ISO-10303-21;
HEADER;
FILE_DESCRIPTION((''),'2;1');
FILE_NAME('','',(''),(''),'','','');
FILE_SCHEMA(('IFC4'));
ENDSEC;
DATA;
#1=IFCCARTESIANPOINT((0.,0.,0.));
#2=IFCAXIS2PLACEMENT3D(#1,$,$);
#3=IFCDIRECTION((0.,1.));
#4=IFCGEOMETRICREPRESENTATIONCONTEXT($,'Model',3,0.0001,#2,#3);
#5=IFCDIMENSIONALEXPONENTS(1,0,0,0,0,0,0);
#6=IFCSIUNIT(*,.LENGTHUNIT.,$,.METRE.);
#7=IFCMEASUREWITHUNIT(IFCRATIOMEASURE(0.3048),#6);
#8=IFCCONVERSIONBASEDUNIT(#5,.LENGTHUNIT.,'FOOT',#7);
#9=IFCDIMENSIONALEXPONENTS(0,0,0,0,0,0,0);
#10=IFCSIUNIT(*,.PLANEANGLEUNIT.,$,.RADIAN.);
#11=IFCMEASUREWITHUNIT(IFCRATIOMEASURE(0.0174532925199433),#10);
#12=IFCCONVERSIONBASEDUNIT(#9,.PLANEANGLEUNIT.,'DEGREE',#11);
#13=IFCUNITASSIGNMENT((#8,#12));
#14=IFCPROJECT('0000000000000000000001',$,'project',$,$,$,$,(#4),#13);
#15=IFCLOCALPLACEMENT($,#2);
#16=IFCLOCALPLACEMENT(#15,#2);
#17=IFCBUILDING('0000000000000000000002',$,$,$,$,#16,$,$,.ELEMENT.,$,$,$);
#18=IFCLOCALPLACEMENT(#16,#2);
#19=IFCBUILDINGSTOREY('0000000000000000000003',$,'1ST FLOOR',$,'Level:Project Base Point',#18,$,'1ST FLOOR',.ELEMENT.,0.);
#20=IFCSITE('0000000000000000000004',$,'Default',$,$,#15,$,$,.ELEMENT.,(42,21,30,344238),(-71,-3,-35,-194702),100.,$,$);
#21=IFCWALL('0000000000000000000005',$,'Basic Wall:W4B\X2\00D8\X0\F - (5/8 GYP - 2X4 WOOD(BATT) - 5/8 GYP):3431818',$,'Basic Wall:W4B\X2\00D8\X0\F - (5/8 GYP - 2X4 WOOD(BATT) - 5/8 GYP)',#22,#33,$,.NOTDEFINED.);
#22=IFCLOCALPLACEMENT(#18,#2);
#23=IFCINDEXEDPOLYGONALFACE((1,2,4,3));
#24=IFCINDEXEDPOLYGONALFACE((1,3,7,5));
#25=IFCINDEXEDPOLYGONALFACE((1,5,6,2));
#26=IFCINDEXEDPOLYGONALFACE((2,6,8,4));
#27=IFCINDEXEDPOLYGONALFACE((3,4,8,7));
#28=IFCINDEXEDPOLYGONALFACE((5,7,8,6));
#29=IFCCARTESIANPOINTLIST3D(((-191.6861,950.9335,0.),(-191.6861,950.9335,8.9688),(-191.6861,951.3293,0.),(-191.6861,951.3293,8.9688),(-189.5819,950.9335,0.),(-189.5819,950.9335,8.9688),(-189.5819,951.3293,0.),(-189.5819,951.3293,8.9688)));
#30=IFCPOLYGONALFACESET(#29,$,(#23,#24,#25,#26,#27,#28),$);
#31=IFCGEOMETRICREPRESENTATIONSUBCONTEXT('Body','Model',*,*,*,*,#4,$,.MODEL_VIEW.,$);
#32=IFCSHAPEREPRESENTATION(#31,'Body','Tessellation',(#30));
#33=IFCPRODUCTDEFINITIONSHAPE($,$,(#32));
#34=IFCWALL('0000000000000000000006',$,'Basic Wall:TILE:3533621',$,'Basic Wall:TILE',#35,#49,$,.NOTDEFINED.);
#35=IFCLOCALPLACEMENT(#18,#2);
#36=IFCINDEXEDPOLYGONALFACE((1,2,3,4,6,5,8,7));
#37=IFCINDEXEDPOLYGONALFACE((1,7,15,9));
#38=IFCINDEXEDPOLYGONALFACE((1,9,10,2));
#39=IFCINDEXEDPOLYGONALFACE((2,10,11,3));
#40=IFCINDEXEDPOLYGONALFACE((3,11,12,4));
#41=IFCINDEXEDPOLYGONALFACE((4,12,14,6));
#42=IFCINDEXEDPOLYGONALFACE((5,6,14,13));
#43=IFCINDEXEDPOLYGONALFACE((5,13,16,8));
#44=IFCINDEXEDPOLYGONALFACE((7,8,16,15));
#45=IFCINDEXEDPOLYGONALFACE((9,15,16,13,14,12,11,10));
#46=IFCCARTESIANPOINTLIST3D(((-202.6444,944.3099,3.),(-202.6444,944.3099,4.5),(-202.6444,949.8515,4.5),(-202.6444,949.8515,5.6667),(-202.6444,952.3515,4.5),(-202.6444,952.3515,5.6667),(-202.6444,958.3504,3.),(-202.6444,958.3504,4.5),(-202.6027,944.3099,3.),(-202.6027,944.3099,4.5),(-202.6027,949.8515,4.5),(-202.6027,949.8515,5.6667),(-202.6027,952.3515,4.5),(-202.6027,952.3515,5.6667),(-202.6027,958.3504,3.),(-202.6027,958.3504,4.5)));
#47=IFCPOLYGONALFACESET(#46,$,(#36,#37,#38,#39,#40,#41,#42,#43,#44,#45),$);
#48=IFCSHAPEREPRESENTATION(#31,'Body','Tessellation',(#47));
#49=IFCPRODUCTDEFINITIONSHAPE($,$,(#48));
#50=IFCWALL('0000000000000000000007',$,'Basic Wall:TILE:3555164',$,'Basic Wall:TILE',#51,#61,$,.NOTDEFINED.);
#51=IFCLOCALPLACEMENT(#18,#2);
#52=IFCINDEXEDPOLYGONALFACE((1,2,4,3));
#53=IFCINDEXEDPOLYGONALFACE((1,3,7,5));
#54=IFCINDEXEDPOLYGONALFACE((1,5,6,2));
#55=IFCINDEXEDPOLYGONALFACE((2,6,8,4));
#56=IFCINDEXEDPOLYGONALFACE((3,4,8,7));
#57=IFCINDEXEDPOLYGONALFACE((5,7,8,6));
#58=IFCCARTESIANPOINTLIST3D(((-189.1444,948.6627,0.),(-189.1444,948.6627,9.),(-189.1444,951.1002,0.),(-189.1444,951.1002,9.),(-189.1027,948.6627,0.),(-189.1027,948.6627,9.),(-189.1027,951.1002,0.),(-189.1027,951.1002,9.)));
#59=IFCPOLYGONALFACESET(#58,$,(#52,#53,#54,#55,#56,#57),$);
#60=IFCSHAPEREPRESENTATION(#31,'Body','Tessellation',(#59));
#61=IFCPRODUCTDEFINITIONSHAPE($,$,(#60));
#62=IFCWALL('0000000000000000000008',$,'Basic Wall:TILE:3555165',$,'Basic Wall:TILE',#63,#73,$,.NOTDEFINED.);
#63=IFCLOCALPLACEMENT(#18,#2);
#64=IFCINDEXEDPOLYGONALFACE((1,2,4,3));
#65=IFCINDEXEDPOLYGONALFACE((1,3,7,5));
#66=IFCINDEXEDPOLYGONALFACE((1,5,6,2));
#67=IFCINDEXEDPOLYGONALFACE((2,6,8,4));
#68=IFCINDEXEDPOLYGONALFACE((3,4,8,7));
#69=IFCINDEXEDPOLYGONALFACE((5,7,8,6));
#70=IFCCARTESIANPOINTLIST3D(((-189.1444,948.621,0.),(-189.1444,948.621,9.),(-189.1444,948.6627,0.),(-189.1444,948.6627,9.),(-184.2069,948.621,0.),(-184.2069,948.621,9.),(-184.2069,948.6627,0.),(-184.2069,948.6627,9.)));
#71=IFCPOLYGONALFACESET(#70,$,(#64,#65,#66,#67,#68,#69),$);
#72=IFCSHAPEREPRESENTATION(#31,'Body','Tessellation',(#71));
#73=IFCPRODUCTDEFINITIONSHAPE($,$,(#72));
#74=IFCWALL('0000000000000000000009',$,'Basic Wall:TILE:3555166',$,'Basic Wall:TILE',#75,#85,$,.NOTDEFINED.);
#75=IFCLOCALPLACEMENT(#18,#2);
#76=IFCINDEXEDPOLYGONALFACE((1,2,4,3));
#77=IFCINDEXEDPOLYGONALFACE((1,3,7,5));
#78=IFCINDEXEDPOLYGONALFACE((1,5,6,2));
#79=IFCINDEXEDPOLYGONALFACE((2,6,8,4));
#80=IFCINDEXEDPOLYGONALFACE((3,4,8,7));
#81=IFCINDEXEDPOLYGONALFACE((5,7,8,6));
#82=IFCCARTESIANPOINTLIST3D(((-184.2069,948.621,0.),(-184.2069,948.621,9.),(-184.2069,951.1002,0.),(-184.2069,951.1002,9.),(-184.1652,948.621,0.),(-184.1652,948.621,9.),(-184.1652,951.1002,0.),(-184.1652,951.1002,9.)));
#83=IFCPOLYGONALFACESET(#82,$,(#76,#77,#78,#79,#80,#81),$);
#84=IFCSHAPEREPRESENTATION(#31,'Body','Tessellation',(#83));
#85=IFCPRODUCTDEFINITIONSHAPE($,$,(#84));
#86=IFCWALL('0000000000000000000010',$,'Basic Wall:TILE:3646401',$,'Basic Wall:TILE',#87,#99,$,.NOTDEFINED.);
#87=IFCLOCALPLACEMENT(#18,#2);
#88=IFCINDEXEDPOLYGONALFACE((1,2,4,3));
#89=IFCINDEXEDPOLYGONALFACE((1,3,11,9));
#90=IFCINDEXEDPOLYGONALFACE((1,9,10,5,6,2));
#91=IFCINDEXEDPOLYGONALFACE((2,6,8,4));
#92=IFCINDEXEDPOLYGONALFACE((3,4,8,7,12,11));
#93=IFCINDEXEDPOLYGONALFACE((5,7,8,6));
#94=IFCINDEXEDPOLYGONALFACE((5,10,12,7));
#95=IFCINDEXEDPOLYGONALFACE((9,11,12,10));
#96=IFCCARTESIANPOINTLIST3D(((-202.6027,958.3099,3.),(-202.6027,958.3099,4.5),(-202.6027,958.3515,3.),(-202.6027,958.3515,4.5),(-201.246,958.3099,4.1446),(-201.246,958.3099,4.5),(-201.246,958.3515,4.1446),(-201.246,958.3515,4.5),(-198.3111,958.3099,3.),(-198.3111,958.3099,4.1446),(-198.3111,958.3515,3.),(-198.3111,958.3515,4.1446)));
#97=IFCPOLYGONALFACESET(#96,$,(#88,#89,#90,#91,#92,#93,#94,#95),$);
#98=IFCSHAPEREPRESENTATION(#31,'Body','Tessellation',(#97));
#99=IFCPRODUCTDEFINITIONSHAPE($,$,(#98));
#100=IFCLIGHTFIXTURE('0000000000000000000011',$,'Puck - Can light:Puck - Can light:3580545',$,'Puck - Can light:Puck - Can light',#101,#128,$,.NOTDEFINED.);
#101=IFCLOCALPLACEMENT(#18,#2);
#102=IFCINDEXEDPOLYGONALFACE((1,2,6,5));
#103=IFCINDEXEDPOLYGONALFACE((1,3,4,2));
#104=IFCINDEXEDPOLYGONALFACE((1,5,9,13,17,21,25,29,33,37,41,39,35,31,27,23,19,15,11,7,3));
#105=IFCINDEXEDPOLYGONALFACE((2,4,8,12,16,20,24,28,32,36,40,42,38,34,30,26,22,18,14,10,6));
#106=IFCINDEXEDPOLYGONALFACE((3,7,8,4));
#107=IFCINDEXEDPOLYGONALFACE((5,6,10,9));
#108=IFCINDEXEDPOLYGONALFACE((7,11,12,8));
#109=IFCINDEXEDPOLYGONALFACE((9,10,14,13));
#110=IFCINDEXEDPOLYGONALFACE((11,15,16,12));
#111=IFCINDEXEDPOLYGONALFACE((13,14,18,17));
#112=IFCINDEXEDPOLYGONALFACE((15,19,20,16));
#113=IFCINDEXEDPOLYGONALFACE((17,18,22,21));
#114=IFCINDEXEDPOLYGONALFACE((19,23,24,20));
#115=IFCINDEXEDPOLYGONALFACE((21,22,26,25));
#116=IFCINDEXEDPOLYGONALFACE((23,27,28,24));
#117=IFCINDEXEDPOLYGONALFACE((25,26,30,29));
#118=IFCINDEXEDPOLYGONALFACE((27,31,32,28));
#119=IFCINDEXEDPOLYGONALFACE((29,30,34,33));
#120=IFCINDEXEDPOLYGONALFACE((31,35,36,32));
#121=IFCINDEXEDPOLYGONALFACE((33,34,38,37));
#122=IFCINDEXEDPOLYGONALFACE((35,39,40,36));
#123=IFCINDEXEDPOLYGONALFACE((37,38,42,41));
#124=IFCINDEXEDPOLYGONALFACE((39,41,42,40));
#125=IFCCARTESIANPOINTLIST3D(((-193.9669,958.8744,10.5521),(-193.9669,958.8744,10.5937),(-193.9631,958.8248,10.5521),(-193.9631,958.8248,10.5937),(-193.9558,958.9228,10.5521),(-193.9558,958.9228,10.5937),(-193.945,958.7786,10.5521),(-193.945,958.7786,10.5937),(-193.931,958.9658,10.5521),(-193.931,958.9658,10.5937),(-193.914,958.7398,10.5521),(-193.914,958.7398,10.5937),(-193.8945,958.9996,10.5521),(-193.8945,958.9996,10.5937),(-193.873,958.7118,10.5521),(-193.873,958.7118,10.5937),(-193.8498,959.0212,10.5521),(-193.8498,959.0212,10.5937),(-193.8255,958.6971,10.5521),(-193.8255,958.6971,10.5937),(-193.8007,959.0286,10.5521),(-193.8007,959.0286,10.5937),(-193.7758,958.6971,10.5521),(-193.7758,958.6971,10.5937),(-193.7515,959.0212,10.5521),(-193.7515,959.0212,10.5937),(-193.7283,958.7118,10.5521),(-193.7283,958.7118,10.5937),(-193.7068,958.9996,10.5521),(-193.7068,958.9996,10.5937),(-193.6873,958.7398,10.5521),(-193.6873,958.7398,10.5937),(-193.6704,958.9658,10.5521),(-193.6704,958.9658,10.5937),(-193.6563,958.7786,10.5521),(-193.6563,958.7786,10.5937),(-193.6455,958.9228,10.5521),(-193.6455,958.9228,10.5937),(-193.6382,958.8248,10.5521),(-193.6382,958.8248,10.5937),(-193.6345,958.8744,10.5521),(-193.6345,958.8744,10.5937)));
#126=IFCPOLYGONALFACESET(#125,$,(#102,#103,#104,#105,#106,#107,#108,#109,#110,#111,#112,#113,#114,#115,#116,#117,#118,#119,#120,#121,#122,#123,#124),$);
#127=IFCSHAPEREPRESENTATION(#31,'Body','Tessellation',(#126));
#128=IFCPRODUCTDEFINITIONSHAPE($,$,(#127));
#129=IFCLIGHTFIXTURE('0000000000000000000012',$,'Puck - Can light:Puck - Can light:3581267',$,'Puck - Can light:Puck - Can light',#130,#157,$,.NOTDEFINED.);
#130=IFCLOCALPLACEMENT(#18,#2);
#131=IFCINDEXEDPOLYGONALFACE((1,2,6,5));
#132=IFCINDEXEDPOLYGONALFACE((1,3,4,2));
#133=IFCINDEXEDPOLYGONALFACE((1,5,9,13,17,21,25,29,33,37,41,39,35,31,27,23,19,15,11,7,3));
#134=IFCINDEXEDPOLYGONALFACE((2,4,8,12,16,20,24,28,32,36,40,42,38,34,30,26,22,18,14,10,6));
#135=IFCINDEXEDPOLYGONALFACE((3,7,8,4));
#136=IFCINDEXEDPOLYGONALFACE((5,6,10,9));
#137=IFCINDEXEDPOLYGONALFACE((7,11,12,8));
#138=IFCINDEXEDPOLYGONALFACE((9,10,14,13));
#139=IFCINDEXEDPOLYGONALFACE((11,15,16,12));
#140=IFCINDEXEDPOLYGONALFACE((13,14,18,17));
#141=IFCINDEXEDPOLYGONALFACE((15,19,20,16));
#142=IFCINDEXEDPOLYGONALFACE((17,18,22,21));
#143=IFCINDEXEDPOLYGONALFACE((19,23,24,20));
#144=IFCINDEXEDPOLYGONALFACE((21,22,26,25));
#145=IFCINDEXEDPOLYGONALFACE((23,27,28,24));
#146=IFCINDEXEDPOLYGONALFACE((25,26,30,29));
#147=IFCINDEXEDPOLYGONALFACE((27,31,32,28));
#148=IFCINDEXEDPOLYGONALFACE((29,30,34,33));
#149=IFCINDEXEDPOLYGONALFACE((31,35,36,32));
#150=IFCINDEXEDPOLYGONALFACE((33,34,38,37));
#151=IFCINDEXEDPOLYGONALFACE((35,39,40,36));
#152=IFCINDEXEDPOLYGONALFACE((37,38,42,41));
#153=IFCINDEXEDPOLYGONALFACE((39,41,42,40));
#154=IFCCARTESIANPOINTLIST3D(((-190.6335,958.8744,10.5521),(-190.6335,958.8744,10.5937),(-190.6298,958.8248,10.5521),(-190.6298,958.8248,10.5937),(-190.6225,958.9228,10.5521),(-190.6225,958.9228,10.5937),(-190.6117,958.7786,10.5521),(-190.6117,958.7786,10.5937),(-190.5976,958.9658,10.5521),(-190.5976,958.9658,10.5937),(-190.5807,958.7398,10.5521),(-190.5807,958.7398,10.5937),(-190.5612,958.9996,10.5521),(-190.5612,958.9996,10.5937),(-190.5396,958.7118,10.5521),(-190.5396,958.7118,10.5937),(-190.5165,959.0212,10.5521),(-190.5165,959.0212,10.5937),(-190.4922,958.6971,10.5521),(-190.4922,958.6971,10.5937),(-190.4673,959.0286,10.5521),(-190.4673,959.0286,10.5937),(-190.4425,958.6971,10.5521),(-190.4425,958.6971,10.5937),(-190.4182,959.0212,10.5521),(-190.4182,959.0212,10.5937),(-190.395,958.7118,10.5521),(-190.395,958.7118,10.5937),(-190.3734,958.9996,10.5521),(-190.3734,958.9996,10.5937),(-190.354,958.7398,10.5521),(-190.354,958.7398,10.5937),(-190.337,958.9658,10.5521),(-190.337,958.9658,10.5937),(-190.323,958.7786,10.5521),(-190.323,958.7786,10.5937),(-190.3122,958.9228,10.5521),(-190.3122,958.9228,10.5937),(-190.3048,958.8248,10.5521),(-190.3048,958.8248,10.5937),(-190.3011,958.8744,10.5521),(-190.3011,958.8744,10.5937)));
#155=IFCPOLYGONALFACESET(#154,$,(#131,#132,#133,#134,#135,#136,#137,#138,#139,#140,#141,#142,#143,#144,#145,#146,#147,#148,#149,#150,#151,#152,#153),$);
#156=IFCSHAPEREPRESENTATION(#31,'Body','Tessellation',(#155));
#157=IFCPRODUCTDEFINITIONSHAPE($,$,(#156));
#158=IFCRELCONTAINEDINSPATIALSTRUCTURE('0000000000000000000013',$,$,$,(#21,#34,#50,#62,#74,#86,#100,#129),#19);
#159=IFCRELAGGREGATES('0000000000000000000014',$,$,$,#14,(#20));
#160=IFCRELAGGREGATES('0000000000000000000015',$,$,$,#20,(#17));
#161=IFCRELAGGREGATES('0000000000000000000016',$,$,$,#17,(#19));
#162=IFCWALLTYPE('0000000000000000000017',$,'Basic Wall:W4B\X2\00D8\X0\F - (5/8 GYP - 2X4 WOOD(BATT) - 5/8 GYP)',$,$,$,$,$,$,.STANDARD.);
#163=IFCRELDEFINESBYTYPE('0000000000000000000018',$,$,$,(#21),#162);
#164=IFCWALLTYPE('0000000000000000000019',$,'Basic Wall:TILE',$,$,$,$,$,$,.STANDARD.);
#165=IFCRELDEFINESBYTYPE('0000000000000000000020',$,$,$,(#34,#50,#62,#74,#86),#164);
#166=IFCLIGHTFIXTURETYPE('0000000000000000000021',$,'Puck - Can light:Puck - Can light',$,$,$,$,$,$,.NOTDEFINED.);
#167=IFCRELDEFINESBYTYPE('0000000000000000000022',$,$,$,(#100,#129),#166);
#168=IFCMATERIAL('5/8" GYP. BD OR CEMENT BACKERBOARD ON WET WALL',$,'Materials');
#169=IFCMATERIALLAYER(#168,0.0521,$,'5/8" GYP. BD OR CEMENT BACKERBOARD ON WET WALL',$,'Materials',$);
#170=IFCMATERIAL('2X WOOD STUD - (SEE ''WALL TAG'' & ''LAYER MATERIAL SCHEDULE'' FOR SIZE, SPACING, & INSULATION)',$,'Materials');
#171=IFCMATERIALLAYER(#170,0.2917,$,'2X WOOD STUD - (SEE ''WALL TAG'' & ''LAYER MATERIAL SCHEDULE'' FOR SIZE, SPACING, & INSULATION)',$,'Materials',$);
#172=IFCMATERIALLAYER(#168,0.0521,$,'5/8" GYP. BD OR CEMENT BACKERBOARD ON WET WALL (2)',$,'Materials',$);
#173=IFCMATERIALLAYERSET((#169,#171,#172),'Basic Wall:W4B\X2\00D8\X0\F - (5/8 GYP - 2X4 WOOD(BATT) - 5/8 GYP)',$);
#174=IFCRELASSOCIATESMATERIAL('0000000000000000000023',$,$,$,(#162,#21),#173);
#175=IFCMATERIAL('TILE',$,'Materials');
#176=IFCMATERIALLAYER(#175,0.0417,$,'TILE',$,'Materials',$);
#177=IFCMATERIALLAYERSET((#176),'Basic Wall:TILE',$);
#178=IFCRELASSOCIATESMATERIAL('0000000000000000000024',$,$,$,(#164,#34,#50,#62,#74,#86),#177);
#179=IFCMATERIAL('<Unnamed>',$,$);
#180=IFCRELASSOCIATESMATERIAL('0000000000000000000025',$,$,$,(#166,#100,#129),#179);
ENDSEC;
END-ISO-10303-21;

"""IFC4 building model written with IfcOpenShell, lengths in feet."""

from ifc_helpers import new_model, entity, si_unit, converted_unit, direction, frame, frame_2d, origin, origin_2d_with_axis, place, context, subcontext, project, spatial, rectangle, circle, extrude, source, transform, mapped, material, layer, layer_set, layer_usage, type_object, type_shapes, element, save


model = new_model("IFC4")

# Units and contexts
model_context = context("Model", 3, precision=0.0001, world=origin(), true_north=direction((0.0, 1.0)))
body_context = subcontext(model_context, "Body", "Model", "MODEL_VIEW")
ifc_project = project(units=[converted_unit("LENGTHUNIT", "FOOT", entity("IfcRatioMeasure", 0.3048), si_unit("LENGTHUNIT", "METRE"), dimensions=[1, 0, 0, 0, 0, 0, 0]), converted_unit("PLANEANGLEUNIT", "DEGREE", entity("IfcRatioMeasure", 0.0174532925199433), si_unit("PLANEANGLEUNIT", "RADIAN"), dimensions=[0, 0, 0, 0, 0, 0, 0])], contexts=[model_context])

# Site, building, storey
site_placement = place(None, origin())
site = spatial("IfcSite", under=ifc_project, at=site_placement, Name="Default", CompositionType="ELEMENT", RefLatitude=(42, 21, 30, 344238), RefLongitude=(-71, -3, -35, -194702), RefElevation=100.0)
building_placement = place(site_placement, origin())
building = spatial("IfcBuilding", under=site, at=building_placement, CompositionType="ELEMENT")
storey_placement = place(building_placement, origin())
storey = spatial("IfcBuildingStorey", under=building, at=storey_placement, Name="1ST FLOOR", ObjectType="Level:Project Base Point", LongName="1ST FLOOR", CompositionType="ELEMENT", Elevation=0.0)

# Shared definitions
ifc_material_1 = material(Name="5/8\" GYP. BD OR CEMENT BACKERBOARD ON WET WALL", Category="Materials")
ifc_layer_1 = layer(ifc_material_1, 0.0521, Name="5/8\" GYP. BD OR CEMENT BACKERBOARD ON WET WALL", Category="Materials")
ifc_material_2 = material(Name="2X WOOD STUD - (SEE 'WALL TAG' & 'LAYER MATERIAL SCHEDULE' FOR SIZE, SPACING, & INSULATION)", Category="Materials")
ifc_layer_2 = layer(ifc_material_2, 0.2917, Name="2X WOOD STUD - (SEE 'WALL TAG' & 'LAYER MATERIAL SCHEDULE' FOR SIZE, SPACING, & INSULATION)", Category="Materials")
ifc_layer_3 = layer(ifc_material_1, 0.0521, Name="5/8\" GYP. BD OR CEMENT BACKERBOARD ON WET WALL (2)", Category="Materials")
ifc_layer_set_1 = layer_set([ifc_layer_1, ifc_layer_2, ifc_layer_3], Name="Basic Wall:W4BØF - (5/8 GYP - 2X4 WOOD(BATT) - 5/8 GYP)")
wall_type_1 = type_object("IfcWallType", Name="Basic Wall:W4BØF - (5/8 GYP - 2X4 WOOD(BATT) - 5/8 GYP)", PredefinedType="STANDARD", material=ifc_layer_set_1)

# Wall
ifc_layer_usage_1 = layer_usage(ifc_layer_set_1, "AXIS2", "POSITIVE", -0.1979)
wall_1_placement = place(storey_placement, frame((-189.5819, 951.1314, 0.0), z_axis=(0.0, 0.0, 1.0), x_axis=(-1.0, 0.0, 0.0)))
element("IfcWall", 1, at=wall_1_placement, inside=storey, type_object=wall_type_1, material=ifc_layer_usage_1, Name="Basic Wall:W4BØF - (5/8 GYP - 2X4 WOOD(BATT) - 5/8 GYP):3431818", ObjectType="Basic Wall:W4BØF - (5/8 GYP - 2X4 WOOD(BATT) - 5/8 GYP)", PredefinedType="NOTDEFINED", context=body_context, shape_type="SweptSolid", body=[
    extrude(rectangle(XDim=2.1042, YDim=0.3958, at=frame_2d((1.0521, 0.0), x_axis=(-1.0, 0.0))), origin(), (0.0, 0.0, 1.0), 8.9688),
])

# Wall, openings
ifc_material_3 = material(Name="TILE", Category="Materials")
ifc_layer_4 = layer(ifc_material_3, 0.0417, Name="TILE", Category="Materials")
ifc_layer_set_2 = layer_set([ifc_layer_4], Name="Basic Wall:TILE")
ifc_layer_usage_2 = layer_usage(ifc_layer_set_2, "AXIS2", "POSITIVE", -0.0208)
wall_type_2 = type_object("IfcWallType", Name="Basic Wall:TILE", PredefinedType="STANDARD", material=ifc_layer_set_2)
wall_2_placement = place(storey_placement, frame((-202.6236, 958.3504, 3.0), z_axis=(0.0, 0.0, 1.0), x_axis=(0.0, -1.0, 0.0)))
wall_2 = element("IfcWall", 2, at=wall_2_placement, inside=storey, type_object=wall_type_2, material=ifc_layer_usage_2, Name="Basic Wall:TILE:3533621", ObjectType="Basic Wall:TILE", PredefinedType="NOTDEFINED", context=body_context, shape_type="SweptSolid", body=[
    extrude(rectangle(XDim=14.0406, YDim=0.0417, at=frame_2d((7.0203, 0.0), x_axis=(-1.0, 0.0))), origin(), (0.0, 0.0, 1.0), 2.6667),
])
opening_1_placement = place(wall_2_placement, origin())
element("IfcOpeningElement", 3, at=opening_1_placement, cuts=wall_2, PredefinedType="OPENING", context=body_context, shape_type="SweptSolid", body=[
    extrude(rectangle(XDim=1.1667, YDim=5.5417, at=origin_2d_with_axis()), frame((11.2697, 0.0208, 2.0833), z_axis=(0.0, -1.0, 0.0), x_axis=(0.0, 0.0, 1.0)), (0.0, 0.0, 1.0), 0.0417),
])
opening_2_placement = place(wall_2_placement, origin())
element("IfcOpeningElement", 4, at=opening_2_placement, cuts=wall_2, PredefinedType="OPENING", context=body_context, shape_type="SweptSolid", body=[
    extrude(rectangle(XDim=1.1667, YDim=5.9989, at=frame_2d((0.0, 0.0), x_axis=(0.0, 1.0))), frame((2.9994, 0.0208, 2.0833), z_axis=(0.0, -1.0, 0.0), x_axis=(-1.0, 0.0, 0.0)), (0.0, 0.0, 1.0), 0.0417),
])

# Walls
ifc_layer_usage_3 = layer_usage(ifc_layer_set_2, "AXIS2", "POSITIVE", -0.0208)
wall_3_placement = place(storey_placement, frame((-189.1236, 951.1002, 0.0), z_axis=(0.0, 0.0, 1.0), x_axis=(0.0, -1.0, 0.0)))
element("IfcWall", 5, at=wall_3_placement, inside=storey, type_object=wall_type_2, material=ifc_layer_usage_3, Name="Basic Wall:TILE:3555164", ObjectType="Basic Wall:TILE", PredefinedType="NOTDEFINED", context=body_context, shape_type="SweptSolid", body=[
    extrude(rectangle(XDim=2.4375, YDim=0.0417, at=frame_2d((1.2187, 0.0), x_axis=(-1.0, 0.0))), origin(), (0.0, 0.0, 1.0), 9.0),
])
ifc_layer_usage_4 = layer_usage(ifc_layer_set_2, "AXIS2", "POSITIVE", -0.0208)
wall_4_placement = place(storey_placement, frame((-189.1444, 948.6418, 0.0)))
element("IfcWall", 6, at=wall_4_placement, inside=storey, type_object=wall_type_2, material=ifc_layer_usage_4, Name="Basic Wall:TILE:3555165", ObjectType="Basic Wall:TILE", PredefinedType="NOTDEFINED", context=body_context, shape_type="SweptSolid", body=[
    extrude(rectangle(XDim=4.9375, YDim=0.0417, at=frame_2d((2.4688, 0.0), x_axis=(-1.0, 0.0))), origin(), (0.0, 0.0, 1.0), 9.0),
])
ifc_layer_usage_5 = layer_usage(ifc_layer_set_2, "AXIS2", "POSITIVE", -0.0208)
wall_5_placement = place(storey_placement, frame((-184.1861, 948.621, 0.0), z_axis=(0.0, 0.0, 1.0), x_axis=(0.0, 1.0, 0.0)))
element("IfcWall", 7, at=wall_5_placement, inside=storey, type_object=wall_type_2, material=ifc_layer_usage_5, Name="Basic Wall:TILE:3555166", ObjectType="Basic Wall:TILE", PredefinedType="NOTDEFINED", context=body_context, shape_type="SweptSolid", body=[
    extrude(rectangle(XDim=2.4792, YDim=0.0417, at=frame_2d((1.2396, 0.0), x_axis=(-1.0, 0.0))), origin(), (0.0, 0.0, 1.0), 9.0),
])

# Wall, opening
ifc_layer_usage_6 = layer_usage(ifc_layer_set_2, "AXIS2", "NEGATIVE", 0.0208)
wall_6_placement = place(storey_placement, frame((-202.6027, 958.3307, 3.0)))
wall_6 = element("IfcWall", 8, at=wall_6_placement, inside=storey, type_object=wall_type_2, material=ifc_layer_usage_6, Name="Basic Wall:TILE:3646401", ObjectType="Basic Wall:TILE", PredefinedType="NOTDEFINED", context=body_context, shape_type="SweptSolid", body=[
    extrude(rectangle(XDim=4.2917, YDim=0.0417, at=frame_2d((2.1458, 0.0), x_axis=(-1.0, 0.0))), origin(), (0.0, 0.0, 1.0), 1.5),
])
opening_3_placement = place(wall_6_placement, origin())
element("IfcOpeningElement", 9, at=opening_3_placement, cuts=wall_6, PredefinedType="OPENING", context=body_context, shape_type="SweptSolid", body=[
    extrude(rectangle(XDim=0.3554, YDim=2.9349, at=frame_2d((0.0, 0.0), x_axis=(1.0, 0.0))), frame((2.8242, 0.0208, 1.3223), z_axis=(0.0, -1.0, 0.0), x_axis=(0.0, 0.0, 1.0)), (0.0, 0.0, 1.0), 0.0417),
])

# Light fixtures
ifc_material_4 = material(Name="<Unnamed>")
light_fixture_type_1 = type_object("IfcLightFixtureType", Name="Puck - Can light:Puck - Can light", PredefinedType="NOTDEFINED", material=ifc_material_4)
shared_shape_1 = source(origin(), body_context, "Body", "SweptSolid", [
    extrude(circle(Radius=0.1667, at=frame_2d((0.0, 0.0), x_axis=(1.0, 0.0))), frame((0.0, 0.0, -0.0417)), (0.0, 0.0, 1.0), 0.0417),
])
type_shapes(light_fixture_type_1, [shared_shape_1])
for number, where, z_axis, x_axis, name in (
    (10, (-193.8007, 958.8619, 10.5521), (0.0, 0.0, -1.0), (0.0, 1.0, 0.0), "Puck - Can light:Puck - Can light:3580545"),
    (11, (-190.4673, 958.8619, 10.5521), (0.0, 0.0, -1.0), (0.0, 1.0, 0.0), "Puck - Can light:Puck - Can light:3581267"),
):
    element("IfcLightFixture", number, at=place(storey_placement, frame(where, z_axis=z_axis, x_axis=x_axis)), inside=storey, type_object=light_fixture_type_1, material=ifc_material_4, Name=name, ObjectType="Puck - Can light:Puck - Can light", PredefinedType="NOTDEFINED", context=body_context, shape_type="MappedRepresentation", body=[
        mapped(shared_shape_1, transform((0.0, 0.0, 0.0), scale=1.0)),
    ])

save(model, "model.ifc")
